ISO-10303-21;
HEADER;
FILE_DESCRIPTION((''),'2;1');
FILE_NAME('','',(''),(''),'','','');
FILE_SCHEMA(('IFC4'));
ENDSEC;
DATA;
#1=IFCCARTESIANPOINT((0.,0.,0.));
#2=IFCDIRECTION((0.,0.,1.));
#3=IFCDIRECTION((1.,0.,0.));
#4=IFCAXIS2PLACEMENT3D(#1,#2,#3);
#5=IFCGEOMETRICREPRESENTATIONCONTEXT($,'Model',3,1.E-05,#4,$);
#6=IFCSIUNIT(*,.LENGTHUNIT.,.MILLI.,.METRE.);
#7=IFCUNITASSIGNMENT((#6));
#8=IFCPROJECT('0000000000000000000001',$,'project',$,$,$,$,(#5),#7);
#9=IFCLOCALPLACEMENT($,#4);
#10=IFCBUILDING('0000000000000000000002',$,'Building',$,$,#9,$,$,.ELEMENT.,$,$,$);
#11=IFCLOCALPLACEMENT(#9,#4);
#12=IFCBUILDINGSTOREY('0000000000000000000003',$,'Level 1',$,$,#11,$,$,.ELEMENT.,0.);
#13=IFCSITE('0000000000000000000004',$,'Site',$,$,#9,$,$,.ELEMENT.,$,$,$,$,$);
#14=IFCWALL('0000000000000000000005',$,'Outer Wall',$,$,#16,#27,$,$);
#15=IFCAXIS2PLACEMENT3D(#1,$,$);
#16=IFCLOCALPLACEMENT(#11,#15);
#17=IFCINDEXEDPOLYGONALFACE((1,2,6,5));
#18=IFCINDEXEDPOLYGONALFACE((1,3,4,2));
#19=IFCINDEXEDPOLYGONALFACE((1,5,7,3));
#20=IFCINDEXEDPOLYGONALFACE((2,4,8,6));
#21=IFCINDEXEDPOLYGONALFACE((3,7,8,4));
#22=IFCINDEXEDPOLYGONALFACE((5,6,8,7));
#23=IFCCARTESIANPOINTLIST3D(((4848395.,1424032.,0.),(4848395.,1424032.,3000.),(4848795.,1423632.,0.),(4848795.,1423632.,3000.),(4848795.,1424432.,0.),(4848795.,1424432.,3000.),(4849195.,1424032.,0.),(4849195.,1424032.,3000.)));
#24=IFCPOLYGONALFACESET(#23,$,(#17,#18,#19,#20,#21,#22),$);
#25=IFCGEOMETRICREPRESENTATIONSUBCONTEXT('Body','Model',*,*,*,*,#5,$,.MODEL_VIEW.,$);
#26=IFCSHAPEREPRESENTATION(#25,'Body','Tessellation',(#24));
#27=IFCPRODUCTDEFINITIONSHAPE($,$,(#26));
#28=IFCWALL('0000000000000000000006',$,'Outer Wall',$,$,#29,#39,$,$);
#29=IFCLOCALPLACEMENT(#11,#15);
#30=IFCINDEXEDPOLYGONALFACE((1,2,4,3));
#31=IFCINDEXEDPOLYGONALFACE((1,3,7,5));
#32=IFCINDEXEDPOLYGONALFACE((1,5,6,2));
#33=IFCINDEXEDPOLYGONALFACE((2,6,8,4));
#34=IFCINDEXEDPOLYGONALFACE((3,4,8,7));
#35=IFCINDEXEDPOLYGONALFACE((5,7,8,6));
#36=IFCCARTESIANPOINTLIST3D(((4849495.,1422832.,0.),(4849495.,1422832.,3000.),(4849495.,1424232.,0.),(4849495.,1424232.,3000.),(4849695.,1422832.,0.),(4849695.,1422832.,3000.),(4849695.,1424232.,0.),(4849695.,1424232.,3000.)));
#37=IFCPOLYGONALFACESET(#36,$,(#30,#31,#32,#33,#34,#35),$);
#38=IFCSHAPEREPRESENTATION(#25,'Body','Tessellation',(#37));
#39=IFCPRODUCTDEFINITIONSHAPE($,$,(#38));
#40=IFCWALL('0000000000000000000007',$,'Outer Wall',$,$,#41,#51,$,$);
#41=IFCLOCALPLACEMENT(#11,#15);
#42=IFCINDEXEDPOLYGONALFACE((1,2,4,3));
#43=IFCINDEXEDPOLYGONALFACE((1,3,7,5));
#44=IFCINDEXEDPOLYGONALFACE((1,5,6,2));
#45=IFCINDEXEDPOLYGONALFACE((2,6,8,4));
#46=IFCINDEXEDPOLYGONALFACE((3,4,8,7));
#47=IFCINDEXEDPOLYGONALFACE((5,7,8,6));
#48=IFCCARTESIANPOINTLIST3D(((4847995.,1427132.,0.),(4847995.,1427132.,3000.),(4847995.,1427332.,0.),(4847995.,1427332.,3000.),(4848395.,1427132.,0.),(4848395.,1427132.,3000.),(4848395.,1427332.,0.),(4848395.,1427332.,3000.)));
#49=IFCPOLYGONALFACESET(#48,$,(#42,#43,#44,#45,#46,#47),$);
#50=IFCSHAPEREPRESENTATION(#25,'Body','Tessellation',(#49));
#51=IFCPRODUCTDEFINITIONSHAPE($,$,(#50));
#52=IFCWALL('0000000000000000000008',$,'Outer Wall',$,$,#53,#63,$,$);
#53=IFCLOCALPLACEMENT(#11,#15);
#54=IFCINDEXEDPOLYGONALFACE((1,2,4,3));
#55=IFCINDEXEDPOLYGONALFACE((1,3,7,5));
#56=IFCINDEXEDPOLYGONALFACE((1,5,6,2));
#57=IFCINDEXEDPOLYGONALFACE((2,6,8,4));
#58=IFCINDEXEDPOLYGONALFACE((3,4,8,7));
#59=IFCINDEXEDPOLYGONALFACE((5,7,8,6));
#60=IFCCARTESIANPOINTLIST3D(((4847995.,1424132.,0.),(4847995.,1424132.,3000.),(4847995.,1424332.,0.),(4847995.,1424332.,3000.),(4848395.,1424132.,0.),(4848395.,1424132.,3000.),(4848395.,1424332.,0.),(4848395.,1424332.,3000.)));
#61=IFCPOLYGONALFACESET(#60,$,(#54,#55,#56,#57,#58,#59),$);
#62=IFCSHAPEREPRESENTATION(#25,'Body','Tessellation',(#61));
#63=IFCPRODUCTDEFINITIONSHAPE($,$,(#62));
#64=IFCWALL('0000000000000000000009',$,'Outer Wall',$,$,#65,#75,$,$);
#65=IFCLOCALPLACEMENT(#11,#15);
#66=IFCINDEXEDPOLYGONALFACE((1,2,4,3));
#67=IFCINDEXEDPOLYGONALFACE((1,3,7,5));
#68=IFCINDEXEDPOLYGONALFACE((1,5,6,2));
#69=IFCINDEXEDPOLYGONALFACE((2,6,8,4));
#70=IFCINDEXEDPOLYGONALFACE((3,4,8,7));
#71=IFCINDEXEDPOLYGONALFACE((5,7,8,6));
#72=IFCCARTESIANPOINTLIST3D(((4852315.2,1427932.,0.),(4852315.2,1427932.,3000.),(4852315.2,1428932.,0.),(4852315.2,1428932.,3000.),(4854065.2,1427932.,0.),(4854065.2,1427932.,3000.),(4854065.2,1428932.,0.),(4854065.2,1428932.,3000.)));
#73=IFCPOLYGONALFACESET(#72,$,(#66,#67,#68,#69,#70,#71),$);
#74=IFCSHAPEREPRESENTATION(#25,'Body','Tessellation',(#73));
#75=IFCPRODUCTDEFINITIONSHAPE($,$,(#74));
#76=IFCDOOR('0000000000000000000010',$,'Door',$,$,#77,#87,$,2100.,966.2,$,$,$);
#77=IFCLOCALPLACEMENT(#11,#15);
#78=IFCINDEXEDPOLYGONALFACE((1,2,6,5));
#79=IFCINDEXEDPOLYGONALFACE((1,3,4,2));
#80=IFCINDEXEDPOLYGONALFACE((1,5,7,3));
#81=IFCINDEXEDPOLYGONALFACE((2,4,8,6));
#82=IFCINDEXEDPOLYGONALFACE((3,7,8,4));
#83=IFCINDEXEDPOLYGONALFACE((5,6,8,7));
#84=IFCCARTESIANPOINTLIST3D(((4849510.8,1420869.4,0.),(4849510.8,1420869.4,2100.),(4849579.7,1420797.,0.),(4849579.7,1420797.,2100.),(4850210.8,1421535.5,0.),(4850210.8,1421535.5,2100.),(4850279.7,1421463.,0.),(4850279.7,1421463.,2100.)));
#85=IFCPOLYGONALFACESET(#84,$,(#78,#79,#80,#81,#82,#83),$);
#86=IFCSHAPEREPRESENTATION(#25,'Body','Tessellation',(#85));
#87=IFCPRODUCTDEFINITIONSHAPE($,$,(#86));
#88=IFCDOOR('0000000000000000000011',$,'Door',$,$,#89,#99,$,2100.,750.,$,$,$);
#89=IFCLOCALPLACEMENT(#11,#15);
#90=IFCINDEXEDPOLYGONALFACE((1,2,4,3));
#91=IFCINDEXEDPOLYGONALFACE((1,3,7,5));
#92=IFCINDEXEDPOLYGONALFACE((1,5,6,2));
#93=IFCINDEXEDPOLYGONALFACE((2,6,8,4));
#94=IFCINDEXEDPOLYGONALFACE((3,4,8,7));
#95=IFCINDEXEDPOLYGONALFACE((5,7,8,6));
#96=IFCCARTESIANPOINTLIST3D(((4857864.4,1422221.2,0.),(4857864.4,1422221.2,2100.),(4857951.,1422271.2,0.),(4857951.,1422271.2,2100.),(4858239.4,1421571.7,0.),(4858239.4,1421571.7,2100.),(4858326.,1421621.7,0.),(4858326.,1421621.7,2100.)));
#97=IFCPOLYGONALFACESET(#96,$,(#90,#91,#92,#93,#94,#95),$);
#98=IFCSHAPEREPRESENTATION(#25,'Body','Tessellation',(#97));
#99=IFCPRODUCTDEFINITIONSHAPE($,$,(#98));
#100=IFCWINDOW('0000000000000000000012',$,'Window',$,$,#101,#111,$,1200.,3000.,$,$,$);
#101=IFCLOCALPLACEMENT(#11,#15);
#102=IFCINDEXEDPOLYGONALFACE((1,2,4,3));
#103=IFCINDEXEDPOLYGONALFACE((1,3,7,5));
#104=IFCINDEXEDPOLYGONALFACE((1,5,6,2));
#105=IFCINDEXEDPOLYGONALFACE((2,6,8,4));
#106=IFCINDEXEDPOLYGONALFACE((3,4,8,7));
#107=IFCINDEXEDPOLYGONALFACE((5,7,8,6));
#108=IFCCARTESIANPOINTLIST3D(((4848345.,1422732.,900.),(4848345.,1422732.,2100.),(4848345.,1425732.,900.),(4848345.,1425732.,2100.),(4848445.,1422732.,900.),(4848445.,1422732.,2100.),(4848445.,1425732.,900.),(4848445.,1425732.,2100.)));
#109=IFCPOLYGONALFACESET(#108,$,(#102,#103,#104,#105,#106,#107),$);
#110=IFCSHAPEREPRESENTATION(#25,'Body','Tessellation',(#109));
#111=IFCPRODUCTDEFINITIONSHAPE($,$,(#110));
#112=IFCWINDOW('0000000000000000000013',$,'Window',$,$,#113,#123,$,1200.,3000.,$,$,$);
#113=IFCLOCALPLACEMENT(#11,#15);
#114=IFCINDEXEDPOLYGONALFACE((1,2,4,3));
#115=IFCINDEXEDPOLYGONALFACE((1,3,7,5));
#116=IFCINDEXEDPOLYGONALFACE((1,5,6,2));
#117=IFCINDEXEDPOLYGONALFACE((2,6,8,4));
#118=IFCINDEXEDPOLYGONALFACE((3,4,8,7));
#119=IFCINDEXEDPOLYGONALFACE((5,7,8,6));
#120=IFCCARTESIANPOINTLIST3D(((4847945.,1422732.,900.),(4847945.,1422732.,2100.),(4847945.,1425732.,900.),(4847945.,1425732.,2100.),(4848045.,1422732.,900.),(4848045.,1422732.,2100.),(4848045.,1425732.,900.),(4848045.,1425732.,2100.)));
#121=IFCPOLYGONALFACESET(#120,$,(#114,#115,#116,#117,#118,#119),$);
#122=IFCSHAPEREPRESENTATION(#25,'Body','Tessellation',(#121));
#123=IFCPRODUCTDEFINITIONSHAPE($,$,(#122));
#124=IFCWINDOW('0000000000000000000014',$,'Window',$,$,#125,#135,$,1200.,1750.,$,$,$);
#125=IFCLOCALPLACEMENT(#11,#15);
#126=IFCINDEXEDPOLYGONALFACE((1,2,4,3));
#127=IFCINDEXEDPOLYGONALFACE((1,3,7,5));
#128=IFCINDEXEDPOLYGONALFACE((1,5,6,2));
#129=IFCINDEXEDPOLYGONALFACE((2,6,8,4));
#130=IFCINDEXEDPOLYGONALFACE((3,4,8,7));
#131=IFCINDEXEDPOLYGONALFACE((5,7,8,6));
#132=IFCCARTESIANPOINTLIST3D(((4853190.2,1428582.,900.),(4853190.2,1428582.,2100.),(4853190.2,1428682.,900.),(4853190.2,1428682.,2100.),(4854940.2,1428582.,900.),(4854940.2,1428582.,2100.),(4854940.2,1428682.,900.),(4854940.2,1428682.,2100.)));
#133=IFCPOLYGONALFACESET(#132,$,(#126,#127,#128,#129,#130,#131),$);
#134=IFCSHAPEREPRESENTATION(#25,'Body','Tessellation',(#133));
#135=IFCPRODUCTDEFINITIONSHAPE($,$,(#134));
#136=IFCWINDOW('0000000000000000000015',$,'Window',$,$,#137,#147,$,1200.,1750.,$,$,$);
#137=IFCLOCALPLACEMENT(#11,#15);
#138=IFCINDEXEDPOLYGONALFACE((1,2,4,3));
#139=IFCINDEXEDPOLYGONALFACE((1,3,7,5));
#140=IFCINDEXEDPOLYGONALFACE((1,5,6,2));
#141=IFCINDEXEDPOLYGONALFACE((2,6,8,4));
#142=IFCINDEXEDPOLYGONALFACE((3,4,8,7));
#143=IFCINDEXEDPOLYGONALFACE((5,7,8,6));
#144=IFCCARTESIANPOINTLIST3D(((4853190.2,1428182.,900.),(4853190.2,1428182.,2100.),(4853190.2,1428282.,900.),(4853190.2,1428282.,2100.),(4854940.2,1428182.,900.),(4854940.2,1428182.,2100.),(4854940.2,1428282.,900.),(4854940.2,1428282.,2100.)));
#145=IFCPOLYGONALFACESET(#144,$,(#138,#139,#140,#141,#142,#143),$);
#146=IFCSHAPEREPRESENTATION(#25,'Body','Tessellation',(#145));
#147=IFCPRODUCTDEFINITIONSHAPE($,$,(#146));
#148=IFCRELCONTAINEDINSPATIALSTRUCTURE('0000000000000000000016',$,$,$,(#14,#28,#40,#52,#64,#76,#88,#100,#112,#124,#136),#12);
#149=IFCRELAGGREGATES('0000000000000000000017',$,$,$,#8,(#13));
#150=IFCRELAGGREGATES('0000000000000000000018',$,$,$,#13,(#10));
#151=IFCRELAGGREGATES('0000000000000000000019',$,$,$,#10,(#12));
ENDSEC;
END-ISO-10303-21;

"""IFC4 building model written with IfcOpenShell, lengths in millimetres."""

from ifc_helpers import new_model, si_unit, frame, frame_2d, origin_with_axes, place, context, subcontext, project, spatial, rectangle, extrude, element, save


model = new_model("IFC4")

# Units and contexts
model_context = context("Model", 3, precision=1e-05, world=origin_with_axes())
body_context = subcontext(model_context, "Body", "Model", "MODEL_VIEW")
ifc_project = project(units=[si_unit("LENGTHUNIT", "METRE", prefix="MILLI")], contexts=[model_context])

# Site, building, storey
placement = place(None, origin_with_axes())
site = spatial("IfcSite", under=ifc_project, at=placement, Name="Site", CompositionType="ELEMENT")
building = spatial("IfcBuilding", under=site, at=placement, Name="Building", CompositionType="ELEMENT")
storey_placement = place(placement, origin_with_axes())
storey = spatial("IfcBuildingStorey", under=building, at=storey_placement, Name="Level 1", CompositionType="ELEMENT", Elevation=0.0)

# Walls
wall_1_placement = place(placement, frame((4848995.0, 1424232.0, 0.0), z_axis=(0.0, 0.0, 1.0), x_axis=(-0.707107, -0.707107, 0.0)))
element("IfcWall", 1, at=wall_1_placement, inside=storey, Name="Outer Wall", context=body_context, shape_type="SweptSolid", body=[
    extrude(rectangle(XDim=565.7, YDim=565.7, at=frame_2d((282.8, 0.0), x_axis=(1.0, 0.0))), origin_with_axes(), (0.0, 0.0, 1.0), 3000.0),
])
wall_2_placement = place(placement, frame((4849595.0, 1422832.0, 0.0), z_axis=(0.0, 0.0, 1.0), x_axis=(0.0, 1.0, 0.0)))
element("IfcWall", 2, at=wall_2_placement, inside=storey, Name="Outer Wall", context=body_context, shape_type="SweptSolid", body=[
    extrude(rectangle(XDim=1400.0, YDim=200.0, at=frame_2d((700.0, 0.0), x_axis=(1.0, 0.0))), origin_with_axes(), (0.0, 0.0, 1.0), 3000.0),
])
for number, where, z_axis, x_axis, name in (
    (3, (4847995.0, 1427232.0, 0.0), (0.0, 0.0, 1.0), (1.0, 0.0, 0.0), "Outer Wall"),
    (4, (4847995.0, 1424232.0, 0.0), (0.0, 0.0, 1.0), (1.0, 0.0, 0.0), "Outer Wall"),
):
    element("IfcWall", number, at=place(placement, frame(where, z_axis=z_axis, x_axis=x_axis)), inside=storey, Name=name, context=body_context, shape_type="SweptSolid", body=[
        extrude(rectangle(XDim=400.0, YDim=200.0, at=frame_2d((200.0, 0.0), x_axis=(1.0, 0.0))), origin_with_axes(), (0.0, 0.0, 1.0), 3000.0),
    ])
wall_3_placement = place(placement, frame((4852315.2, 1428432.0, 0.0), z_axis=(0.0, 0.0, 1.0), x_axis=(1.0, 0.0, 0.0)))
element("IfcWall", 5, at=wall_3_placement, inside=storey, Name="Outer Wall", context=body_context, shape_type="SweptSolid", body=[
    extrude(rectangle(XDim=1750.0, YDim=1000.0, at=frame_2d((875.0, 0.0), x_axis=(1.0, 0.0))), origin_with_axes(), (0.0, 0.0, 1.0), 3000.0),
])

# Doors
door_1_placement = place(placement, frame((4850245.2, 1421499.2, 0.0), z_axis=(0.0, 0.0, 1.0), x_axis=(-0.724469, -0.689307, 0.0)))
element("IfcDoor", 6, at=door_1_placement, inside=storey, Name="Door", OverallHeight=2100.0, OverallWidth=966.2, context=body_context, shape_type="SweptSolid", body=[
    extrude(rectangle(XDim=966.2, YDim=100.0, at=frame_2d((483.1, 0.0), x_axis=(1.0, 0.0))), origin_with_axes(), (0.0, 0.0, 1.0), 2100.0),
])
door_2_placement = place(placement, frame((4858282.7, 1421596.7, 0.0), z_axis=(0.0, 0.0, 1.0), x_axis=(-0.5, 0.866025, 0.0)))
element("IfcDoor", 7, at=door_2_placement, inside=storey, Name="Door", OverallHeight=2100.0, OverallWidth=750.0, context=body_context, shape_type="SweptSolid", body=[
    extrude(rectangle(XDim=750.0, YDim=100.0, at=frame_2d((375.0, 0.0), x_axis=(1.0, 0.0))), origin_with_axes(), (0.0, 0.0, 1.0), 2100.0),
])

# Windows
for number, where, z_axis, x_axis, name in (
    (8, (4848395.0, 1425732.0, 900.0), (0.0, 0.0, 1.0), (0.0, -1.0, 0.0), "Window"),
    (9, (4847995.0, 1425732.0, 900.0), (0.0, 0.0, 1.0), (0.0, -1.0, 0.0), "Window"),
):
    element("IfcWindow", number, at=place(placement, frame(where, z_axis=z_axis, x_axis=x_axis)), inside=storey, Name=name, OverallHeight=1200.0, OverallWidth=3000.0, context=body_context, shape_type="SweptSolid", body=[
        extrude(rectangle(XDim=3000.0, YDim=100.0, at=frame_2d((1500.0, 0.0), x_axis=(1.0, 0.0))), origin_with_axes(), (0.0, 0.0, 1.0), 1200.0),
    ])
for number, where, z_axis, x_axis, name in (
    (10, (4853190.2, 1428632.0, 900.0), (0.0, 0.0, 1.0), (1.0, 0.0, 0.0), "Window"),
    (11, (4853190.2, 1428232.0, 900.0), (0.0, 0.0, 1.0), (1.0, 0.0, 0.0), "Window"),
):
    element("IfcWindow", number, at=place(placement, frame(where, z_axis=z_axis, x_axis=x_axis)), inside=storey, Name=name, OverallHeight=1200.0, OverallWidth=1750.0, context=body_context, shape_type="SweptSolid", body=[
        extrude(rectangle(XDim=1750.0, YDim=100.0, at=frame_2d((875.0, 0.0), x_axis=(1.0, 0.0))), origin_with_axes(), (0.0, 0.0, 1.0), 1200.0),
    ])

save(model, "model.ifc")
